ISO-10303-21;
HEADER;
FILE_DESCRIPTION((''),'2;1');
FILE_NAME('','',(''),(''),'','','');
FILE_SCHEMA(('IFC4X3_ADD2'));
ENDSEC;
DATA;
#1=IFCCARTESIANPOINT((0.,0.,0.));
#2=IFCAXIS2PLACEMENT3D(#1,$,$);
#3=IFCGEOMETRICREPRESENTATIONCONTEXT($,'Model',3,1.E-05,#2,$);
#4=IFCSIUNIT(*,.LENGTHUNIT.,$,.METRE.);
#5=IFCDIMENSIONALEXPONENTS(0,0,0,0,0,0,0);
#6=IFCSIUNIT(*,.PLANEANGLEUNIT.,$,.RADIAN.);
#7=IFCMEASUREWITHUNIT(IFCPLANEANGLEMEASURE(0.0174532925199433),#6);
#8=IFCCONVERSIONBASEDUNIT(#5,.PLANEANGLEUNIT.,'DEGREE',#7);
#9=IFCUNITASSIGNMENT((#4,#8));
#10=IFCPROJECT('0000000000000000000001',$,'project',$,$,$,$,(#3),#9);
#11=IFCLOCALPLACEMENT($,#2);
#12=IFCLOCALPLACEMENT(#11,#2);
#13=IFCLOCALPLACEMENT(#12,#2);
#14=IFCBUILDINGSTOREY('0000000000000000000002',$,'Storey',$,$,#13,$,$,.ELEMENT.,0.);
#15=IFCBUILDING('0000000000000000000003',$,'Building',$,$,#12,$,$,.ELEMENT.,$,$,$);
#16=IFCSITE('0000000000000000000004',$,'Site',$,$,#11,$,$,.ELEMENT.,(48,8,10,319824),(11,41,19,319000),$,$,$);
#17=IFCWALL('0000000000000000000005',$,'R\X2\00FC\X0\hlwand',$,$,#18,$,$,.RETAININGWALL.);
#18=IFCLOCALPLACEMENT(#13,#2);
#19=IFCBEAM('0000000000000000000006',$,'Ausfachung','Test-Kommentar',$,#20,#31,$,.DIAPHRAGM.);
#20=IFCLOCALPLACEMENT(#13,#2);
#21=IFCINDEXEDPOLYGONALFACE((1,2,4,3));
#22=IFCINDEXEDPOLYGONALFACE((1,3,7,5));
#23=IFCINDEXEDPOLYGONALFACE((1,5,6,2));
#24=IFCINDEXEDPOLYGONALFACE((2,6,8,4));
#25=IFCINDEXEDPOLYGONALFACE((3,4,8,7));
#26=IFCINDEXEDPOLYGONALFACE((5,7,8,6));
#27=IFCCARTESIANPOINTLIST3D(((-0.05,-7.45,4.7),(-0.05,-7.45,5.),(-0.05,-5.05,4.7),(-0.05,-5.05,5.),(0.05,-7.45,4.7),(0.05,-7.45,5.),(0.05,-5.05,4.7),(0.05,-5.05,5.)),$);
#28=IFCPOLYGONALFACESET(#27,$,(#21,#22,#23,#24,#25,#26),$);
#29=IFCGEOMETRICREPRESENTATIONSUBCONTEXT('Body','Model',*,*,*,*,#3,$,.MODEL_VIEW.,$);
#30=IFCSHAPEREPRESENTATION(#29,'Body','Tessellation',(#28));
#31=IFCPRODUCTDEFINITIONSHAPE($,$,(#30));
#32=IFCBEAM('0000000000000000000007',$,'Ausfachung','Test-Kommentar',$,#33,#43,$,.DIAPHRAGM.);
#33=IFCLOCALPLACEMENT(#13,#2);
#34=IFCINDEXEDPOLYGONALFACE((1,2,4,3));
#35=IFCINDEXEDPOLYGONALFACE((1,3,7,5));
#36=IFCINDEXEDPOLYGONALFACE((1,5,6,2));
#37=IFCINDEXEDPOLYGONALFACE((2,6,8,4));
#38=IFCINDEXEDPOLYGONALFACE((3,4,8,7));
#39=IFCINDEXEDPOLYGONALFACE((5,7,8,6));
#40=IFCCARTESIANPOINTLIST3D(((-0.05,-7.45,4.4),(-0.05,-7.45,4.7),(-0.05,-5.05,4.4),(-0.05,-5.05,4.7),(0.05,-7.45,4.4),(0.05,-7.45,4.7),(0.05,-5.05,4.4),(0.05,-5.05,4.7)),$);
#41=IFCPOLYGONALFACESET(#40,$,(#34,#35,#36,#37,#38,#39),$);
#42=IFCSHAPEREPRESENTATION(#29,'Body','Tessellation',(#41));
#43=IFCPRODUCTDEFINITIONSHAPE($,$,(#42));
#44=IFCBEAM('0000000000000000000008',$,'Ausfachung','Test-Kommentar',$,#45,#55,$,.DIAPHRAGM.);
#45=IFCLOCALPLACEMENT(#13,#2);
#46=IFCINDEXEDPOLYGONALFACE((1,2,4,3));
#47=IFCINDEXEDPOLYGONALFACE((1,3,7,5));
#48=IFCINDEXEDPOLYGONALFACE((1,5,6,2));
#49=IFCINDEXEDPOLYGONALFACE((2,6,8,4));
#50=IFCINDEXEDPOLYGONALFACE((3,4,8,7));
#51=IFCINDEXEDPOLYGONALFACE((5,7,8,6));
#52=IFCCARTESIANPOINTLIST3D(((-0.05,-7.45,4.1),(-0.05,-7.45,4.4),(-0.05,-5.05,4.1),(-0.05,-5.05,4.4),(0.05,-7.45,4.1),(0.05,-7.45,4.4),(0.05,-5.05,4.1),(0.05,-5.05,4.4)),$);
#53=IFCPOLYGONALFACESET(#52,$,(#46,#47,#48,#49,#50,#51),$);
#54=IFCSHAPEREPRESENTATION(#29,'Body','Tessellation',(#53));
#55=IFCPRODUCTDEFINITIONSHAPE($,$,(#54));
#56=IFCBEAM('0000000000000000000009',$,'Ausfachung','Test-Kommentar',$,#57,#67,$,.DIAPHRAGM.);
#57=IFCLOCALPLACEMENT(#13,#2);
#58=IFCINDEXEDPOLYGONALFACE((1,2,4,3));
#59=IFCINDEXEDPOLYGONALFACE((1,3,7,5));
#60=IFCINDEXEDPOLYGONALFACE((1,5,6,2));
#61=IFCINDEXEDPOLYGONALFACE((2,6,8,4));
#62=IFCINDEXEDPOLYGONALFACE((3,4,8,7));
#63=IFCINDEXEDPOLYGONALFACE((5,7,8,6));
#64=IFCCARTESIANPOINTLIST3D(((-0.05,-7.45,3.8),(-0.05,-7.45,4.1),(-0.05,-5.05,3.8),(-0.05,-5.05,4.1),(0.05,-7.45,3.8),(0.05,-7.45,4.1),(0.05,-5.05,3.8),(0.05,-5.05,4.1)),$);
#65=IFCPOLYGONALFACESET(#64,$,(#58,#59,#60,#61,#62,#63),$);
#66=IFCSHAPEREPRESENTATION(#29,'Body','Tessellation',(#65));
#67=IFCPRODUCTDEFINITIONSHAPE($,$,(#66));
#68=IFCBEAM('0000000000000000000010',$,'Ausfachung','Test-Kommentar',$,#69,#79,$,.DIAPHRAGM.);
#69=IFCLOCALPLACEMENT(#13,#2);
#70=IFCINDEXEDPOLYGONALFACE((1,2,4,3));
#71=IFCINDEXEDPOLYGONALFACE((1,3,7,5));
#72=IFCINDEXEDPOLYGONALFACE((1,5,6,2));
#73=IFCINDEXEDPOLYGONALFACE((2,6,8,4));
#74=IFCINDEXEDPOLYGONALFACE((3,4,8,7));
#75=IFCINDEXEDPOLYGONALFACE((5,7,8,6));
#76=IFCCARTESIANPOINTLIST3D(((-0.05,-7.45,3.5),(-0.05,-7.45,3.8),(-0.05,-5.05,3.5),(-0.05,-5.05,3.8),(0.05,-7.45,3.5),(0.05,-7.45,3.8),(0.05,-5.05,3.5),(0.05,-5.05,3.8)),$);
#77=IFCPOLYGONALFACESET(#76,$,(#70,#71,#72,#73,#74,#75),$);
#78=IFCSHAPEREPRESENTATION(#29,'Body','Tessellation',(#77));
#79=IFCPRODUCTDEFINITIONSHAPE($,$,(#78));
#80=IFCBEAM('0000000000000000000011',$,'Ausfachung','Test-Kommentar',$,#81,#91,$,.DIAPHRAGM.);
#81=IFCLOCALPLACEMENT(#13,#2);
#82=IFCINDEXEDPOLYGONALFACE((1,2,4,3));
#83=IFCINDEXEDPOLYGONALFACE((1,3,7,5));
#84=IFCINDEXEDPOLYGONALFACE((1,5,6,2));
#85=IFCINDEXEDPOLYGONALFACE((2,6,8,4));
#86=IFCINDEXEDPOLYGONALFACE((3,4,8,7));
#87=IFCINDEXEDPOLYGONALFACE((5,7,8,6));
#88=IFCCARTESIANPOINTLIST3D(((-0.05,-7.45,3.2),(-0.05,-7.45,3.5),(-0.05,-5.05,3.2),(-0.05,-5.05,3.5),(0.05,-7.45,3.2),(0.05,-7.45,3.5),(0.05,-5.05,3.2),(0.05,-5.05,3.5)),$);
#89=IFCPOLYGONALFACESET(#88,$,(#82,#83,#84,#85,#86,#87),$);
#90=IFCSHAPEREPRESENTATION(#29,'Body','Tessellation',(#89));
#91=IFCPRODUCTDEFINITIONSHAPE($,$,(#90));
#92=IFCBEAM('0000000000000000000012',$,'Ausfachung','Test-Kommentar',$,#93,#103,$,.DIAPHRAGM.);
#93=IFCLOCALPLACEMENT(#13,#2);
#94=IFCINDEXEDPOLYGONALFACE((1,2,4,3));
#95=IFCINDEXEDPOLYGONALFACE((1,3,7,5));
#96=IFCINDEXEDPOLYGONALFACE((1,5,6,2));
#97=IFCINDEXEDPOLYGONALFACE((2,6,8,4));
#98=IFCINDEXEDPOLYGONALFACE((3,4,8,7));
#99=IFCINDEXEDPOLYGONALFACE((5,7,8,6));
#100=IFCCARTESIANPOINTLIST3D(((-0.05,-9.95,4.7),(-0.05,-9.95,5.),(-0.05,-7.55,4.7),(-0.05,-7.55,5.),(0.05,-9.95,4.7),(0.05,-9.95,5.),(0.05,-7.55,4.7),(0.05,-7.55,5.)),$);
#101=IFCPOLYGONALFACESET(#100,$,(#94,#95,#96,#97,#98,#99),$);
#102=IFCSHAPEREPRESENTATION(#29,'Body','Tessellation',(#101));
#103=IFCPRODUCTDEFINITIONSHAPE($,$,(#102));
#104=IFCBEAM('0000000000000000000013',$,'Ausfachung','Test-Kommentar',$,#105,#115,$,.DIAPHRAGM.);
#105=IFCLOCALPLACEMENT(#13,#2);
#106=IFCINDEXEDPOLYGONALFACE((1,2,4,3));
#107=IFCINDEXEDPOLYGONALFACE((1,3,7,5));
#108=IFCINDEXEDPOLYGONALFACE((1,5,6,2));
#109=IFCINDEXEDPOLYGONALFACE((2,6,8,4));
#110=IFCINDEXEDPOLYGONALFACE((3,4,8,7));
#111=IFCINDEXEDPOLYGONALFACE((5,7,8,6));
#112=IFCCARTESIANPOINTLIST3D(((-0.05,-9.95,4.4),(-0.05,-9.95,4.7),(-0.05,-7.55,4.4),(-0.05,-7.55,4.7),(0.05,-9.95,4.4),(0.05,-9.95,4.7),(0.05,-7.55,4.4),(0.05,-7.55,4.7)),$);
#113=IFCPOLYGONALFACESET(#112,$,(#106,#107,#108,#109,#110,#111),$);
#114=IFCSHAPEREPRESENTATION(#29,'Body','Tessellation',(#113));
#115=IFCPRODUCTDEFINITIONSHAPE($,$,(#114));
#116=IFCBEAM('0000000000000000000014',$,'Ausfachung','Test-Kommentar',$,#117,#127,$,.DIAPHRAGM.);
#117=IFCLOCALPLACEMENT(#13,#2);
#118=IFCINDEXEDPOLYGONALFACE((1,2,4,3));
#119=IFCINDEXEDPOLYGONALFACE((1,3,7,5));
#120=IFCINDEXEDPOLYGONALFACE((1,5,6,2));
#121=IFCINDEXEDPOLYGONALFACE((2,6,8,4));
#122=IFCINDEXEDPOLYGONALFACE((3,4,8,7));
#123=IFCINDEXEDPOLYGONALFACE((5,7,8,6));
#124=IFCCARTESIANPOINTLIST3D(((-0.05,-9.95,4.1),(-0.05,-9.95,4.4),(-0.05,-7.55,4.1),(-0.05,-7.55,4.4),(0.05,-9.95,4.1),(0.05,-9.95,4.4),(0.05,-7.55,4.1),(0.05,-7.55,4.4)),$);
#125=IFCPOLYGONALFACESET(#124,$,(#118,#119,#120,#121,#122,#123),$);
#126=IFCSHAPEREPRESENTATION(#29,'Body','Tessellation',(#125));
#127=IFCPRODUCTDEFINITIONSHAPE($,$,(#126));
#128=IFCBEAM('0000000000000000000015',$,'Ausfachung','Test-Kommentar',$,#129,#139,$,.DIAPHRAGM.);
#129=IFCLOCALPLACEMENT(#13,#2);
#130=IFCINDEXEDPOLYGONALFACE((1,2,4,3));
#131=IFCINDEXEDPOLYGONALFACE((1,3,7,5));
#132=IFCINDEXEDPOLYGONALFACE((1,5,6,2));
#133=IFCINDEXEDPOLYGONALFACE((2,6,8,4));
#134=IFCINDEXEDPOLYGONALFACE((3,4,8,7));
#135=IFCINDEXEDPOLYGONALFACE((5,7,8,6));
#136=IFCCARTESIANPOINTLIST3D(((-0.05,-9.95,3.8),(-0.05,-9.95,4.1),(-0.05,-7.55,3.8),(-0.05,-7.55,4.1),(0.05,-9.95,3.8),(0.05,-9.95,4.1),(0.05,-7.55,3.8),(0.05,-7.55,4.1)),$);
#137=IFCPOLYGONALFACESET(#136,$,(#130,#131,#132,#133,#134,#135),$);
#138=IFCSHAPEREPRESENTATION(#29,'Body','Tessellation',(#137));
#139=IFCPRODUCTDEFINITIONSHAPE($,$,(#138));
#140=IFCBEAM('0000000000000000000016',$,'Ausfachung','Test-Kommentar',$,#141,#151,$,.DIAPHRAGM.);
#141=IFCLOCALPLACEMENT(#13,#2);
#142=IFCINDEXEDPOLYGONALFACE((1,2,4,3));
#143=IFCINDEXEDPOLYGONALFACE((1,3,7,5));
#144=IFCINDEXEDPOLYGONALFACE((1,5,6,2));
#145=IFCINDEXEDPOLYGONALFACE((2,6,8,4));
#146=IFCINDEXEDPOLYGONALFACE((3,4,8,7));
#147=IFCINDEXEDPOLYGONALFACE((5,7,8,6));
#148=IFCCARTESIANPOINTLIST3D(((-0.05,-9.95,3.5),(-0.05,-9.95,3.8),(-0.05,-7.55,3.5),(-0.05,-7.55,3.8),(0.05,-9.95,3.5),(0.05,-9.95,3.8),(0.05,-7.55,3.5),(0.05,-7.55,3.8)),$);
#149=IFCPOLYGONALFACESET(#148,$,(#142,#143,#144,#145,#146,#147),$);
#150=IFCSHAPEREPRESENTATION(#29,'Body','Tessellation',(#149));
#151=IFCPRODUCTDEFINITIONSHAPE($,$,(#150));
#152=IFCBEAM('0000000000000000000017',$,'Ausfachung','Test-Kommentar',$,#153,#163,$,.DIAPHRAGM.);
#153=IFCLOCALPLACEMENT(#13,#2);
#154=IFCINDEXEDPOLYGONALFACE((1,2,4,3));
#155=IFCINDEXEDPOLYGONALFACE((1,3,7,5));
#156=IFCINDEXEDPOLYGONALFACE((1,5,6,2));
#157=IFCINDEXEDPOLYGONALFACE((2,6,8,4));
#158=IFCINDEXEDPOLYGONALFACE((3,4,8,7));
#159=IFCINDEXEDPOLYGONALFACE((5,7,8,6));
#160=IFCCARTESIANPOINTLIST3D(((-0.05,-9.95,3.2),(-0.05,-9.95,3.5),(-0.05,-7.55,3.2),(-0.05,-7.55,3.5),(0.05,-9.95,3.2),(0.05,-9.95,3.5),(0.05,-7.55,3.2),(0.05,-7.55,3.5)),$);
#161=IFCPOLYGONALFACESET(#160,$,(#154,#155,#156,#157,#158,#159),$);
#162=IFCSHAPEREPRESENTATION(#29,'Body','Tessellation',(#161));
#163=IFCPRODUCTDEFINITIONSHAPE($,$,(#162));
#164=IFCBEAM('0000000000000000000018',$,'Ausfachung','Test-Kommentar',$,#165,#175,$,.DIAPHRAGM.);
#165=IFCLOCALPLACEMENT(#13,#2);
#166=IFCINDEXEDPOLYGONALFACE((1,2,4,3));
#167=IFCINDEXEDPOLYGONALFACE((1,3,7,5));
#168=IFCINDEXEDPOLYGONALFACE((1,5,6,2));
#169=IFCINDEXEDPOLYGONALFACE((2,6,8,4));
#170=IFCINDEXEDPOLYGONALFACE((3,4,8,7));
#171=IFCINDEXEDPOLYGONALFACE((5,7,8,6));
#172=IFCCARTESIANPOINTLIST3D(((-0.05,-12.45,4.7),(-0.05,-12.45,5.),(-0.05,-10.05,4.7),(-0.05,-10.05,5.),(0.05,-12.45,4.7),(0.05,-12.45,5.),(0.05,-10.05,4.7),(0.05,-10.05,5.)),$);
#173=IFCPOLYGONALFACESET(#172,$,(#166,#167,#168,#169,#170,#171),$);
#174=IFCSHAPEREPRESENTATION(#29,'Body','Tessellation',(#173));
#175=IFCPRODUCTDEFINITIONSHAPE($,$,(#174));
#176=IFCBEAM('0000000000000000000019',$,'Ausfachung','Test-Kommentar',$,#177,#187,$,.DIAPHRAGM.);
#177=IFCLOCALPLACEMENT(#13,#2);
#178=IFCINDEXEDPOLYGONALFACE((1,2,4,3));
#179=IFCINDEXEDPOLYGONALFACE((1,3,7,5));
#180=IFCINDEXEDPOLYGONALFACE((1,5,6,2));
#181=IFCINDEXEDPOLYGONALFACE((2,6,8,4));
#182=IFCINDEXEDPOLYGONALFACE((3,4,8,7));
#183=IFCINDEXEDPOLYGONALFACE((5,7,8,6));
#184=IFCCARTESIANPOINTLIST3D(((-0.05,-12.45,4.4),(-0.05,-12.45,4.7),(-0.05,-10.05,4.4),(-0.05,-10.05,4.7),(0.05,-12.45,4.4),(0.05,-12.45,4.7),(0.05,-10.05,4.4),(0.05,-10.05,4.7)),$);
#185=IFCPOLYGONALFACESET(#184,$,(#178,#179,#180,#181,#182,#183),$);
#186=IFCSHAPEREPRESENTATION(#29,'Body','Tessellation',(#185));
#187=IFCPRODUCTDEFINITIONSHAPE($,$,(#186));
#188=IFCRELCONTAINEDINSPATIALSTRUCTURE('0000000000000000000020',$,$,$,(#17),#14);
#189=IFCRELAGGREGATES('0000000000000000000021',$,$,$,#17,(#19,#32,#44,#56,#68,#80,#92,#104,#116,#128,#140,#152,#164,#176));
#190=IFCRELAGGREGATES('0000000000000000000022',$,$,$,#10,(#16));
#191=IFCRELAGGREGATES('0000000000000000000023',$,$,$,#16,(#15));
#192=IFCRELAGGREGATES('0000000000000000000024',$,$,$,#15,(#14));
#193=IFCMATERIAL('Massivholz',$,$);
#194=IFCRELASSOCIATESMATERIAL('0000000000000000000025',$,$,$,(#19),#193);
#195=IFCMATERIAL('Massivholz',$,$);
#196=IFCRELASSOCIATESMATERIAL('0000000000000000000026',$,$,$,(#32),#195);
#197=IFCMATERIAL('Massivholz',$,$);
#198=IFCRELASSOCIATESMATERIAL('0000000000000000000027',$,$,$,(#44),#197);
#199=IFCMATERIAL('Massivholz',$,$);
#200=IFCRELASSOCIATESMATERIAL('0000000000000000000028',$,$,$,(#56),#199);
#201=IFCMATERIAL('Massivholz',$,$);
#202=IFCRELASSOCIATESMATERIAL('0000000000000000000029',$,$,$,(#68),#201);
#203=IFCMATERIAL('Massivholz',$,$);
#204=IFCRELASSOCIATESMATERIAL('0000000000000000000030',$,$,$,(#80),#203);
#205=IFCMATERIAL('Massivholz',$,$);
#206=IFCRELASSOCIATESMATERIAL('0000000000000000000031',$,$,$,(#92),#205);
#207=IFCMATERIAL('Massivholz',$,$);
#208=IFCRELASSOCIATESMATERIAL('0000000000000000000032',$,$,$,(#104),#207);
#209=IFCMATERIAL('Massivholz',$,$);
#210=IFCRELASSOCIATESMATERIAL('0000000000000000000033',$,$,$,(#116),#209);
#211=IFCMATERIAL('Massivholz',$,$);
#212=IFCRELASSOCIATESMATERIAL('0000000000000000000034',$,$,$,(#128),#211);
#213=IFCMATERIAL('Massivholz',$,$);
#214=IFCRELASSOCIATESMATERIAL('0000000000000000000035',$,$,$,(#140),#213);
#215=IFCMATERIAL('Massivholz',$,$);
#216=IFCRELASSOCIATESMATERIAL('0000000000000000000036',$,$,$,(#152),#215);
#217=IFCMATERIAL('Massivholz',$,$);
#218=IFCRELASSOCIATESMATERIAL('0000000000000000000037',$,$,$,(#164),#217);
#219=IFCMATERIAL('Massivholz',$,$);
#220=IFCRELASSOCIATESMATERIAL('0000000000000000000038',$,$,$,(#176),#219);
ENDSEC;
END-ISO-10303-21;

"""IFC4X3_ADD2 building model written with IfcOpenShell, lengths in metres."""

from ifc_helpers import new_model, entity, si_unit, converted_unit, frame, frame_2d, origin, place, context, subcontext, project, spatial, rectangle, extrude, material, element, aggregate, save


model = new_model("IFC4X3_ADD2")

# Units and contexts
model_context = context("Model", 3, precision=1e-05, world=origin())
body_context = subcontext(model_context, "Body", "Model", "MODEL_VIEW")
ifc_project = project(units=[si_unit("LENGTHUNIT", "METRE"), converted_unit("PLANEANGLEUNIT", "DEGREE", entity("IfcPlaneAngleMeasure", 0.0174532925199433), si_unit("PLANEANGLEUNIT", "RADIAN"), dimensions=[0, 0, 0, 0, 0, 0, 0])], contexts=[model_context])

# Site, building, storey
site_placement = place(None, origin())
site = spatial("IfcSite", under=ifc_project, at=site_placement, Name="Site", CompositionType="ELEMENT", RefLatitude=(48, 8, 10, 319824), RefLongitude=(11, 41, 19, 319000))
building_placement = place(site_placement, origin())
building = spatial("IfcBuilding", under=site, at=building_placement, Name="Building", CompositionType="ELEMENT")
storey_placement = place(building_placement, origin())
storey = spatial("IfcBuildingStorey", under=building, at=storey_placement, Name="Storey", CompositionType="ELEMENT", Elevation=0.0)

# Wall, beams
wall_1_placement = place(storey_placement, origin())
wall_1 = element("IfcWall", 1, at=wall_1_placement, inside=storey, Name="Rühlwand", PredefinedType="RETAININGWALL")
ifc_material_1 = material(Name="Massivholz")
beam_1_placement = place(wall_1_placement, frame((0.05, -5.05, 4.7), z_axis=(0.0, 0.0, 1.0), x_axis=(-1.0, 0.0, 0.0)))
beam_1 = element("IfcBeam", 2, at=beam_1_placement, material=ifc_material_1, Name="Ausfachung", Description="Test-Kommentar", PredefinedType="DIAPHRAGM", context=body_context, shape_type="SweptSolid", body=[
    extrude(rectangle(XDim=2.4, YDim=0.3, at=frame_2d((1.2, 0.15), x_axis=(1.0, 0.0))), frame((0.0, 0.0, 0.0), z_axis=(1.0, 0.0, 0.0), x_axis=(0.0, 1.0, 0.0)), (0.0, 0.0, 1.0), 0.1),
])
ifc_material_2 = material(Name="Massivholz")
beam_2_placement = place(wall_1_placement, frame((0.05, -5.05, 4.4), z_axis=(0.0, 0.0, 1.0), x_axis=(-1.0, 0.0, 0.0)))
beam_2 = element("IfcBeam", 3, at=beam_2_placement, material=ifc_material_2, Name="Ausfachung", Description="Test-Kommentar", PredefinedType="DIAPHRAGM", context=body_context, shape_type="SweptSolid", body=[
    extrude(rectangle(XDim=2.4, YDim=0.3, at=frame_2d((1.2, 0.15), x_axis=(1.0, 0.0))), frame((0.0, 0.0, 0.0), z_axis=(1.0, 0.0, 0.0), x_axis=(0.0, 1.0, 0.0)), (0.0, 0.0, 1.0), 0.1),
])
ifc_material_3 = material(Name="Massivholz")
beam_3_placement = place(wall_1_placement, frame((0.05, -5.05, 4.1), z_axis=(0.0, 0.0, 1.0), x_axis=(-1.0, 0.0, 0.0)))
beam_3 = element("IfcBeam", 4, at=beam_3_placement, material=ifc_material_3, Name="Ausfachung", Description="Test-Kommentar", PredefinedType="DIAPHRAGM", context=body_context, shape_type="SweptSolid", body=[
    extrude(rectangle(XDim=2.4, YDim=0.3, at=frame_2d((1.2, 0.15), x_axis=(1.0, 0.0))), frame((0.0, 0.0, 0.0), z_axis=(1.0, 0.0, 0.0), x_axis=(0.0, 1.0, 0.0)), (0.0, 0.0, 1.0), 0.1),
])
ifc_material_4 = material(Name="Massivholz")
beam_4_placement = place(wall_1_placement, frame((0.05, -5.05, 3.8), z_axis=(0.0, 0.0, 1.0), x_axis=(-1.0, 0.0, 0.0)))
beam_4 = element("IfcBeam", 5, at=beam_4_placement, material=ifc_material_4, Name="Ausfachung", Description="Test-Kommentar", PredefinedType="DIAPHRAGM", context=body_context, shape_type="SweptSolid", body=[
    extrude(rectangle(XDim=2.4, YDim=0.3, at=frame_2d((1.2, 0.15), x_axis=(1.0, 0.0))), frame((0.0, 0.0, 0.0), z_axis=(1.0, 0.0, 0.0), x_axis=(0.0, 1.0, 0.0)), (0.0, 0.0, 1.0), 0.1),
])
ifc_material_5 = material(Name="Massivholz")
beam_5_placement = place(wall_1_placement, frame((0.05, -5.05, 3.5), z_axis=(0.0, 0.0, 1.0), x_axis=(-1.0, 0.0, 0.0)))
beam_5 = element("IfcBeam", 6, at=beam_5_placement, material=ifc_material_5, Name="Ausfachung", Description="Test-Kommentar", PredefinedType="DIAPHRAGM", context=body_context, shape_type="SweptSolid", body=[
    extrude(rectangle(XDim=2.4, YDim=0.3, at=frame_2d((1.2, 0.15), x_axis=(1.0, 0.0))), frame((0.0, 0.0, 0.0), z_axis=(1.0, 0.0, 0.0), x_axis=(0.0, 1.0, 0.0)), (0.0, 0.0, 1.0), 0.1),
])
ifc_material_6 = material(Name="Massivholz")
beam_6_placement = place(wall_1_placement, frame((0.05, -5.05, 3.2), z_axis=(0.0, 0.0, 1.0), x_axis=(-1.0, 0.0, 0.0)))
beam_6 = element("IfcBeam", 7, at=beam_6_placement, material=ifc_material_6, Name="Ausfachung", Description="Test-Kommentar", PredefinedType="DIAPHRAGM", context=body_context, shape_type="SweptSolid", body=[
    extrude(rectangle(XDim=2.4, YDim=0.3, at=frame_2d((1.2, 0.15), x_axis=(1.0, 0.0))), frame((0.0, 0.0, 0.0), z_axis=(1.0, 0.0, 0.0), x_axis=(0.0, 1.0, 0.0)), (0.0, 0.0, 1.0), 0.1),
])
ifc_material_7 = material(Name="Massivholz")
beam_7_placement = place(wall_1_placement, frame((0.05, -7.55, 4.7), z_axis=(0.0, 0.0, 1.0), x_axis=(-1.0, 0.0, 0.0)))
beam_7 = element("IfcBeam", 8, at=beam_7_placement, material=ifc_material_7, Name="Ausfachung", Description="Test-Kommentar", PredefinedType="DIAPHRAGM", context=body_context, shape_type="SweptSolid", body=[
    extrude(rectangle(XDim=2.4, YDim=0.3, at=frame_2d((1.2, 0.15), x_axis=(1.0, 0.0))), frame((0.0, 0.0, 0.0), z_axis=(1.0, 0.0, 0.0), x_axis=(0.0, 1.0, 0.0)), (0.0, 0.0, 1.0), 0.1),
])
ifc_material_8 = material(Name="Massivholz")
beam_8_placement = place(wall_1_placement, frame((0.05, -7.55, 4.4), z_axis=(0.0, 0.0, 1.0), x_axis=(-1.0, 0.0, 0.0)))
beam_8 = element("IfcBeam", 9, at=beam_8_placement, material=ifc_material_8, Name="Ausfachung", Description="Test-Kommentar", PredefinedType="DIAPHRAGM", context=body_context, shape_type="SweptSolid", body=[
    extrude(rectangle(XDim=2.4, YDim=0.3, at=frame_2d((1.2, 0.15), x_axis=(1.0, 0.0))), frame((0.0, 0.0, 0.0), z_axis=(1.0, 0.0, 0.0), x_axis=(0.0, 1.0, 0.0)), (0.0, 0.0, 1.0), 0.1),
])
ifc_material_9 = material(Name="Massivholz")
beam_9_placement = place(wall_1_placement, frame((0.05, -7.55, 4.1), z_axis=(0.0, 0.0, 1.0), x_axis=(-1.0, 0.0, 0.0)))
beam_9 = element("IfcBeam", 10, at=beam_9_placement, material=ifc_material_9, Name="Ausfachung", Description="Test-Kommentar", PredefinedType="DIAPHRAGM", context=body_context, shape_type="SweptSolid", body=[
    extrude(rectangle(XDim=2.4, YDim=0.3, at=frame_2d((1.2, 0.15), x_axis=(1.0, 0.0))), frame((0.0, 0.0, 0.0), z_axis=(1.0, 0.0, 0.0), x_axis=(0.0, 1.0, 0.0)), (0.0, 0.0, 1.0), 0.1),
])
ifc_material_10 = material(Name="Massivholz")
beam_10_placement = place(wall_1_placement, frame((0.05, -7.55, 3.8), z_axis=(0.0, 0.0, 1.0), x_axis=(-1.0, 0.0, 0.0)))
beam_10 = element("IfcBeam", 11, at=beam_10_placement, material=ifc_material_10, Name="Ausfachung", Description="Test-Kommentar", PredefinedType="DIAPHRAGM", context=body_context, shape_type="SweptSolid", body=[
    extrude(rectangle(XDim=2.4, YDim=0.3, at=frame_2d((1.2, 0.15), x_axis=(1.0, 0.0))), frame((0.0, 0.0, 0.0), z_axis=(1.0, 0.0, 0.0), x_axis=(0.0, 1.0, 0.0)), (0.0, 0.0, 1.0), 0.1),
])
ifc_material_11 = material(Name="Massivholz")
beam_11_placement = place(wall_1_placement, frame((0.05, -7.55, 3.5), z_axis=(0.0, 0.0, 1.0), x_axis=(-1.0, 0.0, 0.0)))
beam_11 = element("IfcBeam", 12, at=beam_11_placement, material=ifc_material_11, Name="Ausfachung", Description="Test-Kommentar", PredefinedType="DIAPHRAGM", context=body_context, shape_type="SweptSolid", body=[
    extrude(rectangle(XDim=2.4, YDim=0.3, at=frame_2d((1.2, 0.15), x_axis=(1.0, 0.0))), frame((0.0, 0.0, 0.0), z_axis=(1.0, 0.0, 0.0), x_axis=(0.0, 1.0, 0.0)), (0.0, 0.0, 1.0), 0.1),
])
ifc_material_12 = material(Name="Massivholz")
beam_12_placement = place(wall_1_placement, frame((0.05, -7.55, 3.2), z_axis=(0.0, 0.0, 1.0), x_axis=(-1.0, 0.0, 0.0)))
beam_12 = element("IfcBeam", 13, at=beam_12_placement, material=ifc_material_12, Name="Ausfachung", Description="Test-Kommentar", PredefinedType="DIAPHRAGM", context=body_context, shape_type="SweptSolid", body=[
    extrude(rectangle(XDim=2.4, YDim=0.3, at=frame_2d((1.2, 0.15), x_axis=(1.0, 0.0))), frame((0.0, 0.0, 0.0), z_axis=(1.0, 0.0, 0.0), x_axis=(0.0, 1.0, 0.0)), (0.0, 0.0, 1.0), 0.1),
])
ifc_material_13 = material(Name="Massivholz")
beam_13_placement = place(wall_1_placement, frame((0.05, -10.05, 4.7), z_axis=(0.0, 0.0, 1.0), x_axis=(-1.0, 0.0, 0.0)))
beam_13 = element("IfcBeam", 14, at=beam_13_placement, material=ifc_material_13, Name="Ausfachung", Description="Test-Kommentar", PredefinedType="DIAPHRAGM", context=body_context, shape_type="SweptSolid", body=[
    extrude(rectangle(XDim=2.4, YDim=0.3, at=frame_2d((1.2, 0.15), x_axis=(1.0, 0.0))), frame((0.0, 0.0, 0.0), z_axis=(1.0, 0.0, 0.0), x_axis=(0.0, 1.0, 0.0)), (0.0, 0.0, 1.0), 0.1),
])
ifc_material_14 = material(Name="Massivholz")
beam_14_placement = place(wall_1_placement, frame((0.05, -10.05, 4.4), z_axis=(0.0, 0.0, 1.0), x_axis=(-1.0, 0.0, 0.0)))
beam_14 = element("IfcBeam", 15, at=beam_14_placement, material=ifc_material_14, Name="Ausfachung", Description="Test-Kommentar", PredefinedType="DIAPHRAGM", context=body_context, shape_type="SweptSolid", body=[
    extrude(rectangle(XDim=2.4, YDim=0.3, at=frame_2d((1.2, 0.15), x_axis=(1.0, 0.0))), frame((0.0, 0.0, 0.0), z_axis=(1.0, 0.0, 0.0), x_axis=(0.0, 1.0, 0.0)), (0.0, 0.0, 1.0), 0.1),
])
aggregate(wall_1, [beam_1, beam_2, beam_3, beam_4, beam_5, beam_6, beam_7, beam_8, beam_9, beam_10, beam_11, beam_12, beam_13, beam_14])

save(model, "model.ifc")
